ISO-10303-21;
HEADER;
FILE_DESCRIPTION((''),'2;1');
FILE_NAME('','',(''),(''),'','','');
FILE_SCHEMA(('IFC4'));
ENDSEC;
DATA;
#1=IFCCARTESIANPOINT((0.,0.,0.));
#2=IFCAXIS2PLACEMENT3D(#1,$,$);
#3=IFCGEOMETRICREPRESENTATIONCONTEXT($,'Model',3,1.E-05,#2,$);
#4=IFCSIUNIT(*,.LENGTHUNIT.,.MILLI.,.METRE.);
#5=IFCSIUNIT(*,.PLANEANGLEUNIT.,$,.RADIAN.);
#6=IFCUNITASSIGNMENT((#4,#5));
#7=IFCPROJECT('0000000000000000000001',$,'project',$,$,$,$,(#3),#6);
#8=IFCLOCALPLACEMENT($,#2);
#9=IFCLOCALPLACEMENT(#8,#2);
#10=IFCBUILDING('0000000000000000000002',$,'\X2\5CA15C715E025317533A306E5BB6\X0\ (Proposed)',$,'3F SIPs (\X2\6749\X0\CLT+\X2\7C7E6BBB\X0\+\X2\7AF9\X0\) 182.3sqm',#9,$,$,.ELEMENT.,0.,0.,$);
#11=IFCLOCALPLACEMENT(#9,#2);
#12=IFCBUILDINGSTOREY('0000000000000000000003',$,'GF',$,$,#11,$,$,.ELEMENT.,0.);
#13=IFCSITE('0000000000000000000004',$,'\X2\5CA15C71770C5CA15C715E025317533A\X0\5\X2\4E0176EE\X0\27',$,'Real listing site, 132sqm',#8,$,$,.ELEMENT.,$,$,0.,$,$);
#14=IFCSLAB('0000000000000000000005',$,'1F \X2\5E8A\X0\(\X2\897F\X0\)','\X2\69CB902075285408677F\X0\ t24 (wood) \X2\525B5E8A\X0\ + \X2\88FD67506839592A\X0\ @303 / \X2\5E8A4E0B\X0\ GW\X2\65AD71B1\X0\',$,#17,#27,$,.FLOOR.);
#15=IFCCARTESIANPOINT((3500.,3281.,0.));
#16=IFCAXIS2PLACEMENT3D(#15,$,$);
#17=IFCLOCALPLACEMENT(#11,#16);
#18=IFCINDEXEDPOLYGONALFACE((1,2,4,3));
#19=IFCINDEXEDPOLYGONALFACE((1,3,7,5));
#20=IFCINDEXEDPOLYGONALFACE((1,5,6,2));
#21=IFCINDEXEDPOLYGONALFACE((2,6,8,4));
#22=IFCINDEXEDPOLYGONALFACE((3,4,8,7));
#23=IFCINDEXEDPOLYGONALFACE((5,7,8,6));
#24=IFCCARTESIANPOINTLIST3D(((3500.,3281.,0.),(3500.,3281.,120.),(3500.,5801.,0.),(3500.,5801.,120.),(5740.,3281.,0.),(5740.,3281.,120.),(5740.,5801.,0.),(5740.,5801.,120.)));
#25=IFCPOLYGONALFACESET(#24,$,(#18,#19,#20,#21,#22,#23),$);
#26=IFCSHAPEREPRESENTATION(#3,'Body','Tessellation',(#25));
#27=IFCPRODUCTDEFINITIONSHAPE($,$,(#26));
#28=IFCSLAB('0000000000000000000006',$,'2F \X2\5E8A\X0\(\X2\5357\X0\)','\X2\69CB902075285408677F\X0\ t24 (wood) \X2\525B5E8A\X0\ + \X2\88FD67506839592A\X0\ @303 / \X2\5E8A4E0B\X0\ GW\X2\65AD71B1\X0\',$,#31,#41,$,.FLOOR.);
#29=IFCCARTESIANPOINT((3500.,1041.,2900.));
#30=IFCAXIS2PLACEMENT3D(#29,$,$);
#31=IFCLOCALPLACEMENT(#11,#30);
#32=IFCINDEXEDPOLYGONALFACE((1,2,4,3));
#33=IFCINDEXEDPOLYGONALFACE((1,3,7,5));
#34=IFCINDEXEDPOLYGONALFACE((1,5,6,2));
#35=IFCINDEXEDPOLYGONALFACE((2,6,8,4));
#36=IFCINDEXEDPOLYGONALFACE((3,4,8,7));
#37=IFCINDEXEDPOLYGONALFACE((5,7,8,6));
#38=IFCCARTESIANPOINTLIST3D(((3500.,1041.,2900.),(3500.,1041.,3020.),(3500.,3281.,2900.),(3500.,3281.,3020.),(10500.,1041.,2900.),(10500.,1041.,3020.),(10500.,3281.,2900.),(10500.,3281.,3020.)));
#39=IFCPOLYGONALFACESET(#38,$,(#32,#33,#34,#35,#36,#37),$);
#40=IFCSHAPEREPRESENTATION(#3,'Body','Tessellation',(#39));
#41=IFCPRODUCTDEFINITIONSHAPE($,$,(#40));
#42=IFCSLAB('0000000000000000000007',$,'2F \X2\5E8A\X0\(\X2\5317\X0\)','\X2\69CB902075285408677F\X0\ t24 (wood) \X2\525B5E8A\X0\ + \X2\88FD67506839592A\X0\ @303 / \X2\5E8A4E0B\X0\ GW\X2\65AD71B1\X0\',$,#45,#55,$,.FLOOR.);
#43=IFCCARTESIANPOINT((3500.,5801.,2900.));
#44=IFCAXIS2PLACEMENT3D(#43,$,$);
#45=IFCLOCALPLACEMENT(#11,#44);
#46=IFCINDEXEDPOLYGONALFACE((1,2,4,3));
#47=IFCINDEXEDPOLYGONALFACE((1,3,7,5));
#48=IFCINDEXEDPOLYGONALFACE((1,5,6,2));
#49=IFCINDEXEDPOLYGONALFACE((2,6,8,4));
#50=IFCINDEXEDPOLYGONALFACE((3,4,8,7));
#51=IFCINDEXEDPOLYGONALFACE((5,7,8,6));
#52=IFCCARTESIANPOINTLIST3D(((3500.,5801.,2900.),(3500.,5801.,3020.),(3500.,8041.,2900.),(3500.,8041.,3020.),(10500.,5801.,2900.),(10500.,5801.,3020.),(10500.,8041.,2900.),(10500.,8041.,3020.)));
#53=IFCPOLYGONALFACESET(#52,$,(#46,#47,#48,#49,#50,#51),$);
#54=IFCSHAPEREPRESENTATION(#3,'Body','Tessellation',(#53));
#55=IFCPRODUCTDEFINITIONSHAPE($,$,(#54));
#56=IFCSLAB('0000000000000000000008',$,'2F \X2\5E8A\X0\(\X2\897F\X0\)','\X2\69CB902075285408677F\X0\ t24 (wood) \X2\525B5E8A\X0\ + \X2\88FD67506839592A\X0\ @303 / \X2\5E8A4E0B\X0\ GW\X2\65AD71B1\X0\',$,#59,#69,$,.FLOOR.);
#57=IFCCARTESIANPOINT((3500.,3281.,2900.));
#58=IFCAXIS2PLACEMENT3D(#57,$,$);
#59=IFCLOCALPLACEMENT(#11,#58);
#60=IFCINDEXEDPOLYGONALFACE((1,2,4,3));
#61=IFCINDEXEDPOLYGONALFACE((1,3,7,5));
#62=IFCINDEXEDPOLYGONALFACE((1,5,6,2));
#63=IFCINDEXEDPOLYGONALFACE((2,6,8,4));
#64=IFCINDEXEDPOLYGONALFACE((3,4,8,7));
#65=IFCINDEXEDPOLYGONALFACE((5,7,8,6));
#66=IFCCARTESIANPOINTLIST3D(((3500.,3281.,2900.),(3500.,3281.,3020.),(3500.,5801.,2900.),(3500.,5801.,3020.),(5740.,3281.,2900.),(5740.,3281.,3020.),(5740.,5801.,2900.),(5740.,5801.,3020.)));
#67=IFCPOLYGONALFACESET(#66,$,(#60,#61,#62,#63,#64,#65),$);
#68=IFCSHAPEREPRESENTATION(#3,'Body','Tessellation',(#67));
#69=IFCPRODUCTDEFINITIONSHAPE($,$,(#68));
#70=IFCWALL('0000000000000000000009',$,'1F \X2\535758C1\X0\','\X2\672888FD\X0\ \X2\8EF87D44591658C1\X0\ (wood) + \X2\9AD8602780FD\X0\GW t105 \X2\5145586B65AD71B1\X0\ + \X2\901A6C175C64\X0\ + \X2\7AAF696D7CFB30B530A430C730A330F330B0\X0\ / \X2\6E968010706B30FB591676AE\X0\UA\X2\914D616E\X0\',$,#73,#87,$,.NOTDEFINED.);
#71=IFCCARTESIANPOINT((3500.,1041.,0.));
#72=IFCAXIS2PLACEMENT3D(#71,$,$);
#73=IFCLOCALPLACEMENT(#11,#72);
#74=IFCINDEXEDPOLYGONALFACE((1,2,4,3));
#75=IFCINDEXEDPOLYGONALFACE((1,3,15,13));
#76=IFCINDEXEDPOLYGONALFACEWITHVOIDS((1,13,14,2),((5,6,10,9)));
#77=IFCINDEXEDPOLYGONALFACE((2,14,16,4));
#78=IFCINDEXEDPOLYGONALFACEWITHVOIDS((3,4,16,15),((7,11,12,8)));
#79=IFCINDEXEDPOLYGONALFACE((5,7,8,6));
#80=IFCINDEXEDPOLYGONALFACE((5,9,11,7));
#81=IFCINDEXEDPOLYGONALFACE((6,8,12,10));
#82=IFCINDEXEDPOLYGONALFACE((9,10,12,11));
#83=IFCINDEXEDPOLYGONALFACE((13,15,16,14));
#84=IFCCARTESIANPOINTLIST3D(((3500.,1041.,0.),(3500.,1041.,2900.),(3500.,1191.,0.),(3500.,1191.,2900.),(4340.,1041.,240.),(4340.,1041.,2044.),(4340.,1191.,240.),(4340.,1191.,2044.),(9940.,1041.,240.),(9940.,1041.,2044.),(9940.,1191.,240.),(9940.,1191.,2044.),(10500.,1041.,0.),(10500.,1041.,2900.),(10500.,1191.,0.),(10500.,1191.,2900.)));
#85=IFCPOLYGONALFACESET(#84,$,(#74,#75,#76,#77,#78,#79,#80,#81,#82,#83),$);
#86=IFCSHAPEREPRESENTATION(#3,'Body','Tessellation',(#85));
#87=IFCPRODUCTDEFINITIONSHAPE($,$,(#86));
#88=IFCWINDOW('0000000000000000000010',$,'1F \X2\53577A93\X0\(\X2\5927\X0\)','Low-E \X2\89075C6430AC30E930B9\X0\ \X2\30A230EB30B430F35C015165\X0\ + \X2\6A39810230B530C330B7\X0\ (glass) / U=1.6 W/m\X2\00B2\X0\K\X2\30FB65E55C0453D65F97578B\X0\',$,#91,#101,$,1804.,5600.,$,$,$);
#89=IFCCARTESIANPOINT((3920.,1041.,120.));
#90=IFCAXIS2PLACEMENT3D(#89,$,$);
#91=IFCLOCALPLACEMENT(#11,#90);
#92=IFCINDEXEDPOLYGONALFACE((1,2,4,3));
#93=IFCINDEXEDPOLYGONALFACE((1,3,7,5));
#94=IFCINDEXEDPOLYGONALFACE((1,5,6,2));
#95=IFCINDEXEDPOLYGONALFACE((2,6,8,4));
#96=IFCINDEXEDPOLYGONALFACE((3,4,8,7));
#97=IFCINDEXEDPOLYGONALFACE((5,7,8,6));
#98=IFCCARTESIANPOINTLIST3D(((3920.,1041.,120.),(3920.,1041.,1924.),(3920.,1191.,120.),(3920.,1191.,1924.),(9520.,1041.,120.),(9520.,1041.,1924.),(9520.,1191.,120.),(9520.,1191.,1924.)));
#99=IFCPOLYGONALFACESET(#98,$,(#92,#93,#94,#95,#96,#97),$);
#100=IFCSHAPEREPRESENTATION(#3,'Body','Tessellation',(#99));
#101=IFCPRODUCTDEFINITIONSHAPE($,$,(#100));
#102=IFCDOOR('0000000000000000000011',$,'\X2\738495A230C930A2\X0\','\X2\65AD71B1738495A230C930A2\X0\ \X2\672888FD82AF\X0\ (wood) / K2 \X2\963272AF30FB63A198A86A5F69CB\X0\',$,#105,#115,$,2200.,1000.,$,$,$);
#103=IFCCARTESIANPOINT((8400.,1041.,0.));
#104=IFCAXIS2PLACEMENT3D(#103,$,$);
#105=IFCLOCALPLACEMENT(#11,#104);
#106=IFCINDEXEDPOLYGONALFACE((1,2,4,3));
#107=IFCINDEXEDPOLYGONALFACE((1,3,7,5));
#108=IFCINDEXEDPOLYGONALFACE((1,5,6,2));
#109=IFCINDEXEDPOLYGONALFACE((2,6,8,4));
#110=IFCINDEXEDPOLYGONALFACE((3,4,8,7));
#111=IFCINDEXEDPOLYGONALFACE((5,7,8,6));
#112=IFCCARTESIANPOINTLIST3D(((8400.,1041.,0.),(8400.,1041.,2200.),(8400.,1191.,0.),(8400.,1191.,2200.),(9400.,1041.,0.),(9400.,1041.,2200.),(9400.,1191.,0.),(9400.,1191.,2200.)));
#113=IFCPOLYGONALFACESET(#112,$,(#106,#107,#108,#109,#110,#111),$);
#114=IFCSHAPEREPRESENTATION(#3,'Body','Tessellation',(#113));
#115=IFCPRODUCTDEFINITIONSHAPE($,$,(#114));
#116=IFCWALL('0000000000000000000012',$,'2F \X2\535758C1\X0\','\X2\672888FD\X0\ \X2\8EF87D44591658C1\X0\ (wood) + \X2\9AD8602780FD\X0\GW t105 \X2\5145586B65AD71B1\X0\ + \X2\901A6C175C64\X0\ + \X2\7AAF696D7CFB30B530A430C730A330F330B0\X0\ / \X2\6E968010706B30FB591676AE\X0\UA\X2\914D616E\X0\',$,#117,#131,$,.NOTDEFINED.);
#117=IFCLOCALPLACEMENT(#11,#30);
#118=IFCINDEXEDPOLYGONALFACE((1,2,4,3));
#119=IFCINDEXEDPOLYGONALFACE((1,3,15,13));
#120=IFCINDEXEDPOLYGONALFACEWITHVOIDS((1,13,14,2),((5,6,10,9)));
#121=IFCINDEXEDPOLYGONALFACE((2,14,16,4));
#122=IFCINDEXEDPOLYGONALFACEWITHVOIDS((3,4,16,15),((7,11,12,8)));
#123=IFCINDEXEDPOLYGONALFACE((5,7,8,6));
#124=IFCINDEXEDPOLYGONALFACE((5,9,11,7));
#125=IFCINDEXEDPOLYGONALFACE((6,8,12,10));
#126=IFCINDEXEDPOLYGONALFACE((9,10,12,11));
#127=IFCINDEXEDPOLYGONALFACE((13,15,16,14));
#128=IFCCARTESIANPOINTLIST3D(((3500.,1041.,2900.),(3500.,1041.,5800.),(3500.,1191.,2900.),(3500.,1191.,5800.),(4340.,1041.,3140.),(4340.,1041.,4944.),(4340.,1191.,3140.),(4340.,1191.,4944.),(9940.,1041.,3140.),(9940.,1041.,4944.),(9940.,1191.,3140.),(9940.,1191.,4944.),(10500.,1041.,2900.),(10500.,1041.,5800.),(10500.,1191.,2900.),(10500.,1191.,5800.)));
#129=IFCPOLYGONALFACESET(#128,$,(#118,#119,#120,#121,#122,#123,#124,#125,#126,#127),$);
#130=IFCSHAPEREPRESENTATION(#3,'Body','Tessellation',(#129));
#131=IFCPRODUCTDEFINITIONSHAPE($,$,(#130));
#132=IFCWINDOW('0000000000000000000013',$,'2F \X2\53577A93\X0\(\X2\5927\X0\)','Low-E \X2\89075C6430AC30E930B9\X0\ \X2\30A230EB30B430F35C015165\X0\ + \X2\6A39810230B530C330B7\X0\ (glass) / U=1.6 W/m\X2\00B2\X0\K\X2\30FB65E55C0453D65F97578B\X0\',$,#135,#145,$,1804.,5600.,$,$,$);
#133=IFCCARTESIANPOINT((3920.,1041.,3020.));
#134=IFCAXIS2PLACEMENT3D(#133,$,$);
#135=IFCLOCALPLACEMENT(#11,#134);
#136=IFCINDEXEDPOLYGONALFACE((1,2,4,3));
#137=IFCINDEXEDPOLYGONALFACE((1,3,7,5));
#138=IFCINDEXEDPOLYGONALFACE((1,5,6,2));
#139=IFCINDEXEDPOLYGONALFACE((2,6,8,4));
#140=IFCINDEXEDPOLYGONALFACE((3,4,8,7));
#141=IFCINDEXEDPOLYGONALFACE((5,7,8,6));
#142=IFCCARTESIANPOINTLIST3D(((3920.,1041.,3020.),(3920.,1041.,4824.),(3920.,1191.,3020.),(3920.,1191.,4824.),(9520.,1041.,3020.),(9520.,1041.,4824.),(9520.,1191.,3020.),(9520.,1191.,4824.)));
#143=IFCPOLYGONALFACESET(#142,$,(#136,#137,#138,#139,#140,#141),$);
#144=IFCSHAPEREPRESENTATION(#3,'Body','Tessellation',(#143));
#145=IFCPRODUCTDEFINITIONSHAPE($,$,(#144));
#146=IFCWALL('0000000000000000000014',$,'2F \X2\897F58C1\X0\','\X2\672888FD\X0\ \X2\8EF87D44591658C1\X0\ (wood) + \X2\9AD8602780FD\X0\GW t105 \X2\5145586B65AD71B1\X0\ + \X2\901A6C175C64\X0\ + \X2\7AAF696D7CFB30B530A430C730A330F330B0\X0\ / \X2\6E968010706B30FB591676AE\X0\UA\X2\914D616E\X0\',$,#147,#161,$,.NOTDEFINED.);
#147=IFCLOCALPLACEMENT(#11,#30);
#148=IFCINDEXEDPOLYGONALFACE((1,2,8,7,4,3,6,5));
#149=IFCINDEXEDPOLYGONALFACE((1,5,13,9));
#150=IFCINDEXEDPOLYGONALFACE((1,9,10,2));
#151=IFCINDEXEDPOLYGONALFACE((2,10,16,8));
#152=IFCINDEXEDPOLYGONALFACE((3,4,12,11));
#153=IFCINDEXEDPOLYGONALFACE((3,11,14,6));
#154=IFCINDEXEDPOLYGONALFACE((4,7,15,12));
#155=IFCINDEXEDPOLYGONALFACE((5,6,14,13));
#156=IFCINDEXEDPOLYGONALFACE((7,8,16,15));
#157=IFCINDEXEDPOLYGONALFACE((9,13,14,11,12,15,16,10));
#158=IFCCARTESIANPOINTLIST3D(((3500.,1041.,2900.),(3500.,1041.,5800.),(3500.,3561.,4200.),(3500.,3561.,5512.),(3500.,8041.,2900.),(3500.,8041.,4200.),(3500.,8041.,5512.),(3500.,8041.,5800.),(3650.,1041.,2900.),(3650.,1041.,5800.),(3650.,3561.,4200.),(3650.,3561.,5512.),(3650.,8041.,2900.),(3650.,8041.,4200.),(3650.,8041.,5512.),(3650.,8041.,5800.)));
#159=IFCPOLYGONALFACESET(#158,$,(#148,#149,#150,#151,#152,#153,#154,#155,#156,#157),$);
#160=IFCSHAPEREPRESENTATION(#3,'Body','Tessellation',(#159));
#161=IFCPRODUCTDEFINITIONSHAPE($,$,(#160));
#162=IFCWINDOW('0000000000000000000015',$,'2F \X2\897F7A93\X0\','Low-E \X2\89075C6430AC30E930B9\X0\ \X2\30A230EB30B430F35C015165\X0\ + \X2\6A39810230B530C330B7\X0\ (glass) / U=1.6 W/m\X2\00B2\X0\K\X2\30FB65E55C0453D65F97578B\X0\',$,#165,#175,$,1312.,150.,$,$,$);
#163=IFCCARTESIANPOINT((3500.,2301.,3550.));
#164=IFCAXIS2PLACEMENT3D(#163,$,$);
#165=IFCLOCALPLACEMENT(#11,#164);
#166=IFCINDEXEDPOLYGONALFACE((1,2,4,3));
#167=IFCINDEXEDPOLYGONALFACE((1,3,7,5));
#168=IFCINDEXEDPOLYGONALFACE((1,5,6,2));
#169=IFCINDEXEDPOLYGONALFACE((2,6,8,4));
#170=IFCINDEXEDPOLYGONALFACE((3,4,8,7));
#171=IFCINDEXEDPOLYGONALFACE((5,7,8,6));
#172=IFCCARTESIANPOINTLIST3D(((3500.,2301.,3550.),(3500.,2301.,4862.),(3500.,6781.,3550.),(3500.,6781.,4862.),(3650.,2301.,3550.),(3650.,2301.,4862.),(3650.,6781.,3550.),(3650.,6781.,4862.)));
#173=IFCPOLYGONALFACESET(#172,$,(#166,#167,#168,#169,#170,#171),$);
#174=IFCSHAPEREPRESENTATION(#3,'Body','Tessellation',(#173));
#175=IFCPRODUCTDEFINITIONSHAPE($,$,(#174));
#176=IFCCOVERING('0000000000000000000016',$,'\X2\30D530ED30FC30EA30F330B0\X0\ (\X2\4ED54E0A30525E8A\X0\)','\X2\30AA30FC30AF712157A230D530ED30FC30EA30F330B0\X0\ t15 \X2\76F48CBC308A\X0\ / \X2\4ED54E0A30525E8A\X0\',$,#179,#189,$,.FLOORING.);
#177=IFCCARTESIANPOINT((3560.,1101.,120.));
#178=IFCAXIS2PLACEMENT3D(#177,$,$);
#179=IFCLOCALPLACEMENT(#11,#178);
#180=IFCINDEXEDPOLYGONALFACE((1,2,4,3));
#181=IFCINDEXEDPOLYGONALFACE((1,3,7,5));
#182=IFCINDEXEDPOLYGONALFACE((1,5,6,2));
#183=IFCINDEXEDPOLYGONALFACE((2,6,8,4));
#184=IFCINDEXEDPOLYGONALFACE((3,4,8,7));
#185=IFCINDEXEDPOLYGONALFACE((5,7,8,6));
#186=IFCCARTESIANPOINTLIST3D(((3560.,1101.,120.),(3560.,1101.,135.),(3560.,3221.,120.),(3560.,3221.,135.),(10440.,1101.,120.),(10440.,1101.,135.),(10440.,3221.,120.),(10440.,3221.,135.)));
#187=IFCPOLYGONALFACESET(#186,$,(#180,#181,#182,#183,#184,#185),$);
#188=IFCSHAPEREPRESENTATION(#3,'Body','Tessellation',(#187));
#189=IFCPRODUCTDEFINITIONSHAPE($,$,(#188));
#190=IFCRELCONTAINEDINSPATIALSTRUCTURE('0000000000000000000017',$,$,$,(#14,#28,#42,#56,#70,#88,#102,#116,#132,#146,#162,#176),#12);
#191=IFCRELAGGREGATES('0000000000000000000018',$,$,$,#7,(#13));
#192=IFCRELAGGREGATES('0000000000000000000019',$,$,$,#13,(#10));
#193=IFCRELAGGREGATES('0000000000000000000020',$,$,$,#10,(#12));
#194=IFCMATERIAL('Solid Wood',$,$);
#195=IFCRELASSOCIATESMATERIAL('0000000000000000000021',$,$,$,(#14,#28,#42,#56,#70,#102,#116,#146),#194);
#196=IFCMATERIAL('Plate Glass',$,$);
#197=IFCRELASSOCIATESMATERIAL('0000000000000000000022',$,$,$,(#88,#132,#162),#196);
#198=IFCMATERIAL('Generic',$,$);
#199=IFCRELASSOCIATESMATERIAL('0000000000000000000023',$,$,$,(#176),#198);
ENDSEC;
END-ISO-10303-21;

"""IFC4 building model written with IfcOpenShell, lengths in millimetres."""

from ifc_helpers import new_model, si_unit, frame, frame_2d, origin, place, context, project, spatial, rectangle, extrude, material, element, fill, save


model = new_model("IFC4")

# Units and contexts
model_context = context("Model", 3, precision=1e-05, world=origin())
ifc_project = project(units=[si_unit("LENGTHUNIT", "METRE", prefix="MILLI"), si_unit("PLANEANGLEUNIT", "RADIAN")], contexts=[model_context])

# Site, building, storey
site_placement = place(None, origin())
site = spatial("IfcSite", under=ifc_project, at=site_placement, Name="岡山県岡山市北区5丁目27", ObjectType="Real listing site, 132sqm", CompositionType="ELEMENT", RefElevation=0.0)
building_placement = place(site_placement, origin())
building = spatial("IfcBuilding", under=site, at=building_placement, Name="岡山市北区の家 (Proposed)", ObjectType="3F SIPs (杉CLT+籾殻+竹) 182.3sqm", CompositionType="ELEMENT", ElevationOfRefHeight=0.0, ElevationOfTerrain=0.0)
storey_placement = place(building_placement, origin())
storey = spatial("IfcBuildingStorey", under=building, at=storey_placement, Name="GF", CompositionType="ELEMENT", Elevation=0.0)

# Slabs
ifc_material_1 = material(Name="Solid Wood")
slab_1_placement = place(storey_placement, frame((3500.0, 3281.0, 0.0)))
element("IfcSlab", 1, at=slab_1_placement, inside=storey, material=ifc_material_1, Name="1F 床(西)", Description="構造用合板 t24 (wood) 剛床 + 製材根太 @303 / 床下 GW断熱", PredefinedType="FLOOR", context=model_context, shape_type="SweptSolid", body=[
    extrude(rectangle(XDim=2240.0, YDim=2520.0, at=frame_2d((1120.0, 1260.0))), frame((3500.0, 3281.0, 0.0)), (0.0, 0.0, 1.0), 120.0),
])
slab_2_placement = place(storey_placement, frame((3500.0, 1041.0, 2900.0)))
element("IfcSlab", 2, at=slab_2_placement, inside=storey, material=ifc_material_1, Name="2F 床(南)", Description="構造用合板 t24 (wood) 剛床 + 製材根太 @303 / 床下 GW断熱", PredefinedType="FLOOR", context=model_context, shape_type="SweptSolid", body=[
    extrude(rectangle(XDim=7000.0, YDim=2240.0, at=frame_2d((3500.0, 1120.0))), frame((3500.0, 1041.0, 2900.0)), (0.0, 0.0, 1.0), 120.0),
])
slab_3_placement = place(storey_placement, frame((3500.0, 5801.0, 2900.0)))
element("IfcSlab", 3, at=slab_3_placement, inside=storey, material=ifc_material_1, Name="2F 床(北)", Description="構造用合板 t24 (wood) 剛床 + 製材根太 @303 / 床下 GW断熱", PredefinedType="FLOOR", context=model_context, shape_type="SweptSolid", body=[
    extrude(rectangle(XDim=7000.0, YDim=2240.0, at=frame_2d((3500.0, 1120.0))), frame((3500.0, 5801.0, 2900.0)), (0.0, 0.0, 1.0), 120.0),
])
slab_4_placement = place(storey_placement, frame((3500.0, 3281.0, 2900.0)))
element("IfcSlab", 4, at=slab_4_placement, inside=storey, material=ifc_material_1, Name="2F 床(西)", Description="構造用合板 t24 (wood) 剛床 + 製材根太 @303 / 床下 GW断熱", PredefinedType="FLOOR", context=model_context, shape_type="SweptSolid", body=[
    extrude(rectangle(XDim=2240.0, YDim=2520.0, at=frame_2d((1120.0, 1260.0))), frame((3500.0, 3281.0, 2900.0)), (0.0, 0.0, 1.0), 120.0),
])

# Wall, openings, window, door
wall_1_placement = place(storey_placement, frame((3500.0, 1041.0, 0.0)))
wall_1 = element("IfcWall", 5, at=wall_1_placement, inside=storey, material=ifc_material_1, Name="1F 南壁", Description="木製 軸組外壁 (wood) + 高性能GW t105 充填断熱 + 通気層 + 窯業系サイディング / 準耐火・外皮UA配慮", PredefinedType="NOTDEFINED", context=model_context, shape_type="SweptSolid", body=[
    extrude(rectangle(XDim=7000.0, YDim=150.0, at=frame_2d((3500.0, 75.0))), frame((3500.0, 1041.0, 0.0)), (0.0, 0.0, 1.0), 2900.0),
])
opening_1_placement = place(storey_placement, frame((3920.0, 1041.0, 120.0)))
opening_1 = element("IfcOpeningElement", 6, at=opening_1_placement, cuts=wall_1, PredefinedType="NOTDEFINED", context=model_context, shape_type="SweptSolid", body=[
    extrude(rectangle(XDim=5600.0, YDim=150.0, at=frame_2d((2800.0, 75.0))), frame((3920.0, 1041.0, 120.0)), (0.0, 0.0, 1.0), 1804.0),
])
opening_2_placement = place(storey_placement, frame((8400.0, 1041.0, 0.0)))
opening_2 = element("IfcOpeningElement", 7, at=opening_2_placement, cuts=wall_1, PredefinedType="NOTDEFINED", context=model_context, shape_type="SweptSolid", body=[
    extrude(rectangle(XDim=1000.0, YDim=150.0, at=frame_2d((500.0, 75.0))), frame((8400.0, 1041.0, 0.0)), (0.0, 0.0, 1.0), 2200.0),
])
ifc_material_2 = material(Name="Plate Glass")
window_1_placement = place(storey_placement, frame((3920.0, 1041.0, 120.0)))
window_1 = element("IfcWindow", 8, at=window_1_placement, inside=storey, material=ifc_material_2, Name="1F 南窓(大)", Description="Low-E 複層ガラス アルゴン封入 + 樹脂サッシ (glass) / U=1.6 W/m²K・日射取得型", OverallHeight=1804.0, OverallWidth=5600.0, context=model_context, shape_type="SweptSolid", body=[
    extrude(rectangle(XDim=5600.0, YDim=150.0, at=frame_2d((2800.0, 75.0))), frame((3920.0, 1041.0, 120.0)), (0.0, 0.0, 1.0), 1804.0),
])
fill(opening_1, window_1)
door_placement = place(storey_placement, frame((8400.0, 1041.0, 0.0)))
door = element("IfcDoor", 9, at=door_placement, inside=storey, material=ifc_material_1, Name="玄関ドア", Description="断熱玄関ドア 木製芯 (wood) / K2 防犯・採風機構", OverallHeight=2200.0, OverallWidth=1000.0, context=model_context, shape_type="SweptSolid", body=[
    extrude(rectangle(XDim=1000.0, YDim=150.0, at=frame_2d((500.0, 75.0))), frame((8400.0, 1041.0, 0.0)), (0.0, 0.0, 1.0), 2200.0),
])
fill(opening_2, door)

# Wall, opening, window
wall_2_placement = place(storey_placement, frame((3500.0, 1041.0, 2900.0)))
wall_2 = element("IfcWall", 10, at=wall_2_placement, inside=storey, material=ifc_material_1, Name="2F 南壁", Description="木製 軸組外壁 (wood) + 高性能GW t105 充填断熱 + 通気層 + 窯業系サイディング / 準耐火・外皮UA配慮", PredefinedType="NOTDEFINED", context=model_context, shape_type="SweptSolid", body=[
    extrude(rectangle(XDim=7000.0, YDim=150.0, at=frame_2d((3500.0, 75.0))), frame((3500.0, 1041.0, 2900.0)), (0.0, 0.0, 1.0), 2900.0),
])
opening_3_placement = place(storey_placement, frame((3920.0, 1041.0, 3020.0)))
opening_3 = element("IfcOpeningElement", 11, at=opening_3_placement, cuts=wall_2, PredefinedType="NOTDEFINED", context=model_context, shape_type="SweptSolid", body=[
    extrude(rectangle(XDim=5600.0, YDim=150.0, at=frame_2d((2800.0, 75.0))), frame((3920.0, 1041.0, 3020.0)), (0.0, 0.0, 1.0), 1804.0),
])
window_2_placement = place(storey_placement, frame((3920.0, 1041.0, 3020.0)))
window_2 = element("IfcWindow", 12, at=window_2_placement, inside=storey, material=ifc_material_2, Name="2F 南窓(大)", Description="Low-E 複層ガラス アルゴン封入 + 樹脂サッシ (glass) / U=1.6 W/m²K・日射取得型", OverallHeight=1804.0, OverallWidth=5600.0, context=model_context, shape_type="SweptSolid", body=[
    extrude(rectangle(XDim=5600.0, YDim=150.0, at=frame_2d((2800.0, 75.0))), frame((3920.0, 1041.0, 3020.0)), (0.0, 0.0, 1.0), 1804.0),
])
fill(opening_3, window_2)

# Wall, opening, window
wall_3_placement = place(storey_placement, frame((3500.0, 1041.0, 2900.0)))
wall_3 = element("IfcWall", 13, at=wall_3_placement, inside=storey, material=ifc_material_1, Name="2F 西壁", Description="木製 軸組外壁 (wood) + 高性能GW t105 充填断熱 + 通気層 + 窯業系サイディング / 準耐火・外皮UA配慮", PredefinedType="NOTDEFINED", context=model_context, shape_type="SweptSolid", body=[
    extrude(rectangle(XDim=150.0, YDim=7000.0, at=frame_2d((75.0, 3500.0))), frame((3500.0, 1041.0, 2900.0)), (0.0, 0.0, 1.0), 2900.0),
])
opening_4_placement = place(storey_placement, frame((3500.0, 2301.0, 3550.0)))
opening_4 = element("IfcOpeningElement", 14, at=opening_4_placement, cuts=wall_3, PredefinedType="NOTDEFINED", context=model_context, shape_type="SweptSolid", body=[
    extrude(rectangle(XDim=150.0, YDim=4480.0, at=frame_2d((75.0, 2240.0))), frame((3500.0, 2301.0, 3550.0)), (0.0, 0.0, 1.0), 1312.0),
])
window_3_placement = place(storey_placement, frame((3500.0, 2301.0, 3550.0)))
window_3 = element("IfcWindow", 15, at=window_3_placement, inside=storey, material=ifc_material_2, Name="2F 西窓", Description="Low-E 複層ガラス アルゴン封入 + 樹脂サッシ (glass) / U=1.6 W/m²K・日射取得型", OverallHeight=1312.0, OverallWidth=150.0, context=model_context, shape_type="SweptSolid", body=[
    extrude(rectangle(XDim=150.0, YDim=4480.0, at=frame_2d((75.0, 2240.0))), frame((3500.0, 2301.0, 3550.0)), (0.0, 0.0, 1.0), 1312.0),
])
fill(opening_4, window_3)

# Covering
ifc_material_3 = material(Name="Generic")
covering_1_placement = place(storey_placement, frame((3560.0, 1101.0, 120.0)))
element("IfcCovering", 16, at=covering_1_placement, inside=storey, material=ifc_material_3, Name="フローリング (仕上げ床)", Description="オーク無垢フローリング t15 直貼り / 仕上げ床", PredefinedType="FLOORING", context=model_context, shape_type="SweptSolid", body=[
    extrude(rectangle(XDim=6880.0, YDim=2120.0, at=frame_2d((3440.0, 1060.0))), frame((3560.0, 1101.0, 120.0)), (0.0, 0.0, 1.0), 15.0),
])

save(model, "model.ifc")
